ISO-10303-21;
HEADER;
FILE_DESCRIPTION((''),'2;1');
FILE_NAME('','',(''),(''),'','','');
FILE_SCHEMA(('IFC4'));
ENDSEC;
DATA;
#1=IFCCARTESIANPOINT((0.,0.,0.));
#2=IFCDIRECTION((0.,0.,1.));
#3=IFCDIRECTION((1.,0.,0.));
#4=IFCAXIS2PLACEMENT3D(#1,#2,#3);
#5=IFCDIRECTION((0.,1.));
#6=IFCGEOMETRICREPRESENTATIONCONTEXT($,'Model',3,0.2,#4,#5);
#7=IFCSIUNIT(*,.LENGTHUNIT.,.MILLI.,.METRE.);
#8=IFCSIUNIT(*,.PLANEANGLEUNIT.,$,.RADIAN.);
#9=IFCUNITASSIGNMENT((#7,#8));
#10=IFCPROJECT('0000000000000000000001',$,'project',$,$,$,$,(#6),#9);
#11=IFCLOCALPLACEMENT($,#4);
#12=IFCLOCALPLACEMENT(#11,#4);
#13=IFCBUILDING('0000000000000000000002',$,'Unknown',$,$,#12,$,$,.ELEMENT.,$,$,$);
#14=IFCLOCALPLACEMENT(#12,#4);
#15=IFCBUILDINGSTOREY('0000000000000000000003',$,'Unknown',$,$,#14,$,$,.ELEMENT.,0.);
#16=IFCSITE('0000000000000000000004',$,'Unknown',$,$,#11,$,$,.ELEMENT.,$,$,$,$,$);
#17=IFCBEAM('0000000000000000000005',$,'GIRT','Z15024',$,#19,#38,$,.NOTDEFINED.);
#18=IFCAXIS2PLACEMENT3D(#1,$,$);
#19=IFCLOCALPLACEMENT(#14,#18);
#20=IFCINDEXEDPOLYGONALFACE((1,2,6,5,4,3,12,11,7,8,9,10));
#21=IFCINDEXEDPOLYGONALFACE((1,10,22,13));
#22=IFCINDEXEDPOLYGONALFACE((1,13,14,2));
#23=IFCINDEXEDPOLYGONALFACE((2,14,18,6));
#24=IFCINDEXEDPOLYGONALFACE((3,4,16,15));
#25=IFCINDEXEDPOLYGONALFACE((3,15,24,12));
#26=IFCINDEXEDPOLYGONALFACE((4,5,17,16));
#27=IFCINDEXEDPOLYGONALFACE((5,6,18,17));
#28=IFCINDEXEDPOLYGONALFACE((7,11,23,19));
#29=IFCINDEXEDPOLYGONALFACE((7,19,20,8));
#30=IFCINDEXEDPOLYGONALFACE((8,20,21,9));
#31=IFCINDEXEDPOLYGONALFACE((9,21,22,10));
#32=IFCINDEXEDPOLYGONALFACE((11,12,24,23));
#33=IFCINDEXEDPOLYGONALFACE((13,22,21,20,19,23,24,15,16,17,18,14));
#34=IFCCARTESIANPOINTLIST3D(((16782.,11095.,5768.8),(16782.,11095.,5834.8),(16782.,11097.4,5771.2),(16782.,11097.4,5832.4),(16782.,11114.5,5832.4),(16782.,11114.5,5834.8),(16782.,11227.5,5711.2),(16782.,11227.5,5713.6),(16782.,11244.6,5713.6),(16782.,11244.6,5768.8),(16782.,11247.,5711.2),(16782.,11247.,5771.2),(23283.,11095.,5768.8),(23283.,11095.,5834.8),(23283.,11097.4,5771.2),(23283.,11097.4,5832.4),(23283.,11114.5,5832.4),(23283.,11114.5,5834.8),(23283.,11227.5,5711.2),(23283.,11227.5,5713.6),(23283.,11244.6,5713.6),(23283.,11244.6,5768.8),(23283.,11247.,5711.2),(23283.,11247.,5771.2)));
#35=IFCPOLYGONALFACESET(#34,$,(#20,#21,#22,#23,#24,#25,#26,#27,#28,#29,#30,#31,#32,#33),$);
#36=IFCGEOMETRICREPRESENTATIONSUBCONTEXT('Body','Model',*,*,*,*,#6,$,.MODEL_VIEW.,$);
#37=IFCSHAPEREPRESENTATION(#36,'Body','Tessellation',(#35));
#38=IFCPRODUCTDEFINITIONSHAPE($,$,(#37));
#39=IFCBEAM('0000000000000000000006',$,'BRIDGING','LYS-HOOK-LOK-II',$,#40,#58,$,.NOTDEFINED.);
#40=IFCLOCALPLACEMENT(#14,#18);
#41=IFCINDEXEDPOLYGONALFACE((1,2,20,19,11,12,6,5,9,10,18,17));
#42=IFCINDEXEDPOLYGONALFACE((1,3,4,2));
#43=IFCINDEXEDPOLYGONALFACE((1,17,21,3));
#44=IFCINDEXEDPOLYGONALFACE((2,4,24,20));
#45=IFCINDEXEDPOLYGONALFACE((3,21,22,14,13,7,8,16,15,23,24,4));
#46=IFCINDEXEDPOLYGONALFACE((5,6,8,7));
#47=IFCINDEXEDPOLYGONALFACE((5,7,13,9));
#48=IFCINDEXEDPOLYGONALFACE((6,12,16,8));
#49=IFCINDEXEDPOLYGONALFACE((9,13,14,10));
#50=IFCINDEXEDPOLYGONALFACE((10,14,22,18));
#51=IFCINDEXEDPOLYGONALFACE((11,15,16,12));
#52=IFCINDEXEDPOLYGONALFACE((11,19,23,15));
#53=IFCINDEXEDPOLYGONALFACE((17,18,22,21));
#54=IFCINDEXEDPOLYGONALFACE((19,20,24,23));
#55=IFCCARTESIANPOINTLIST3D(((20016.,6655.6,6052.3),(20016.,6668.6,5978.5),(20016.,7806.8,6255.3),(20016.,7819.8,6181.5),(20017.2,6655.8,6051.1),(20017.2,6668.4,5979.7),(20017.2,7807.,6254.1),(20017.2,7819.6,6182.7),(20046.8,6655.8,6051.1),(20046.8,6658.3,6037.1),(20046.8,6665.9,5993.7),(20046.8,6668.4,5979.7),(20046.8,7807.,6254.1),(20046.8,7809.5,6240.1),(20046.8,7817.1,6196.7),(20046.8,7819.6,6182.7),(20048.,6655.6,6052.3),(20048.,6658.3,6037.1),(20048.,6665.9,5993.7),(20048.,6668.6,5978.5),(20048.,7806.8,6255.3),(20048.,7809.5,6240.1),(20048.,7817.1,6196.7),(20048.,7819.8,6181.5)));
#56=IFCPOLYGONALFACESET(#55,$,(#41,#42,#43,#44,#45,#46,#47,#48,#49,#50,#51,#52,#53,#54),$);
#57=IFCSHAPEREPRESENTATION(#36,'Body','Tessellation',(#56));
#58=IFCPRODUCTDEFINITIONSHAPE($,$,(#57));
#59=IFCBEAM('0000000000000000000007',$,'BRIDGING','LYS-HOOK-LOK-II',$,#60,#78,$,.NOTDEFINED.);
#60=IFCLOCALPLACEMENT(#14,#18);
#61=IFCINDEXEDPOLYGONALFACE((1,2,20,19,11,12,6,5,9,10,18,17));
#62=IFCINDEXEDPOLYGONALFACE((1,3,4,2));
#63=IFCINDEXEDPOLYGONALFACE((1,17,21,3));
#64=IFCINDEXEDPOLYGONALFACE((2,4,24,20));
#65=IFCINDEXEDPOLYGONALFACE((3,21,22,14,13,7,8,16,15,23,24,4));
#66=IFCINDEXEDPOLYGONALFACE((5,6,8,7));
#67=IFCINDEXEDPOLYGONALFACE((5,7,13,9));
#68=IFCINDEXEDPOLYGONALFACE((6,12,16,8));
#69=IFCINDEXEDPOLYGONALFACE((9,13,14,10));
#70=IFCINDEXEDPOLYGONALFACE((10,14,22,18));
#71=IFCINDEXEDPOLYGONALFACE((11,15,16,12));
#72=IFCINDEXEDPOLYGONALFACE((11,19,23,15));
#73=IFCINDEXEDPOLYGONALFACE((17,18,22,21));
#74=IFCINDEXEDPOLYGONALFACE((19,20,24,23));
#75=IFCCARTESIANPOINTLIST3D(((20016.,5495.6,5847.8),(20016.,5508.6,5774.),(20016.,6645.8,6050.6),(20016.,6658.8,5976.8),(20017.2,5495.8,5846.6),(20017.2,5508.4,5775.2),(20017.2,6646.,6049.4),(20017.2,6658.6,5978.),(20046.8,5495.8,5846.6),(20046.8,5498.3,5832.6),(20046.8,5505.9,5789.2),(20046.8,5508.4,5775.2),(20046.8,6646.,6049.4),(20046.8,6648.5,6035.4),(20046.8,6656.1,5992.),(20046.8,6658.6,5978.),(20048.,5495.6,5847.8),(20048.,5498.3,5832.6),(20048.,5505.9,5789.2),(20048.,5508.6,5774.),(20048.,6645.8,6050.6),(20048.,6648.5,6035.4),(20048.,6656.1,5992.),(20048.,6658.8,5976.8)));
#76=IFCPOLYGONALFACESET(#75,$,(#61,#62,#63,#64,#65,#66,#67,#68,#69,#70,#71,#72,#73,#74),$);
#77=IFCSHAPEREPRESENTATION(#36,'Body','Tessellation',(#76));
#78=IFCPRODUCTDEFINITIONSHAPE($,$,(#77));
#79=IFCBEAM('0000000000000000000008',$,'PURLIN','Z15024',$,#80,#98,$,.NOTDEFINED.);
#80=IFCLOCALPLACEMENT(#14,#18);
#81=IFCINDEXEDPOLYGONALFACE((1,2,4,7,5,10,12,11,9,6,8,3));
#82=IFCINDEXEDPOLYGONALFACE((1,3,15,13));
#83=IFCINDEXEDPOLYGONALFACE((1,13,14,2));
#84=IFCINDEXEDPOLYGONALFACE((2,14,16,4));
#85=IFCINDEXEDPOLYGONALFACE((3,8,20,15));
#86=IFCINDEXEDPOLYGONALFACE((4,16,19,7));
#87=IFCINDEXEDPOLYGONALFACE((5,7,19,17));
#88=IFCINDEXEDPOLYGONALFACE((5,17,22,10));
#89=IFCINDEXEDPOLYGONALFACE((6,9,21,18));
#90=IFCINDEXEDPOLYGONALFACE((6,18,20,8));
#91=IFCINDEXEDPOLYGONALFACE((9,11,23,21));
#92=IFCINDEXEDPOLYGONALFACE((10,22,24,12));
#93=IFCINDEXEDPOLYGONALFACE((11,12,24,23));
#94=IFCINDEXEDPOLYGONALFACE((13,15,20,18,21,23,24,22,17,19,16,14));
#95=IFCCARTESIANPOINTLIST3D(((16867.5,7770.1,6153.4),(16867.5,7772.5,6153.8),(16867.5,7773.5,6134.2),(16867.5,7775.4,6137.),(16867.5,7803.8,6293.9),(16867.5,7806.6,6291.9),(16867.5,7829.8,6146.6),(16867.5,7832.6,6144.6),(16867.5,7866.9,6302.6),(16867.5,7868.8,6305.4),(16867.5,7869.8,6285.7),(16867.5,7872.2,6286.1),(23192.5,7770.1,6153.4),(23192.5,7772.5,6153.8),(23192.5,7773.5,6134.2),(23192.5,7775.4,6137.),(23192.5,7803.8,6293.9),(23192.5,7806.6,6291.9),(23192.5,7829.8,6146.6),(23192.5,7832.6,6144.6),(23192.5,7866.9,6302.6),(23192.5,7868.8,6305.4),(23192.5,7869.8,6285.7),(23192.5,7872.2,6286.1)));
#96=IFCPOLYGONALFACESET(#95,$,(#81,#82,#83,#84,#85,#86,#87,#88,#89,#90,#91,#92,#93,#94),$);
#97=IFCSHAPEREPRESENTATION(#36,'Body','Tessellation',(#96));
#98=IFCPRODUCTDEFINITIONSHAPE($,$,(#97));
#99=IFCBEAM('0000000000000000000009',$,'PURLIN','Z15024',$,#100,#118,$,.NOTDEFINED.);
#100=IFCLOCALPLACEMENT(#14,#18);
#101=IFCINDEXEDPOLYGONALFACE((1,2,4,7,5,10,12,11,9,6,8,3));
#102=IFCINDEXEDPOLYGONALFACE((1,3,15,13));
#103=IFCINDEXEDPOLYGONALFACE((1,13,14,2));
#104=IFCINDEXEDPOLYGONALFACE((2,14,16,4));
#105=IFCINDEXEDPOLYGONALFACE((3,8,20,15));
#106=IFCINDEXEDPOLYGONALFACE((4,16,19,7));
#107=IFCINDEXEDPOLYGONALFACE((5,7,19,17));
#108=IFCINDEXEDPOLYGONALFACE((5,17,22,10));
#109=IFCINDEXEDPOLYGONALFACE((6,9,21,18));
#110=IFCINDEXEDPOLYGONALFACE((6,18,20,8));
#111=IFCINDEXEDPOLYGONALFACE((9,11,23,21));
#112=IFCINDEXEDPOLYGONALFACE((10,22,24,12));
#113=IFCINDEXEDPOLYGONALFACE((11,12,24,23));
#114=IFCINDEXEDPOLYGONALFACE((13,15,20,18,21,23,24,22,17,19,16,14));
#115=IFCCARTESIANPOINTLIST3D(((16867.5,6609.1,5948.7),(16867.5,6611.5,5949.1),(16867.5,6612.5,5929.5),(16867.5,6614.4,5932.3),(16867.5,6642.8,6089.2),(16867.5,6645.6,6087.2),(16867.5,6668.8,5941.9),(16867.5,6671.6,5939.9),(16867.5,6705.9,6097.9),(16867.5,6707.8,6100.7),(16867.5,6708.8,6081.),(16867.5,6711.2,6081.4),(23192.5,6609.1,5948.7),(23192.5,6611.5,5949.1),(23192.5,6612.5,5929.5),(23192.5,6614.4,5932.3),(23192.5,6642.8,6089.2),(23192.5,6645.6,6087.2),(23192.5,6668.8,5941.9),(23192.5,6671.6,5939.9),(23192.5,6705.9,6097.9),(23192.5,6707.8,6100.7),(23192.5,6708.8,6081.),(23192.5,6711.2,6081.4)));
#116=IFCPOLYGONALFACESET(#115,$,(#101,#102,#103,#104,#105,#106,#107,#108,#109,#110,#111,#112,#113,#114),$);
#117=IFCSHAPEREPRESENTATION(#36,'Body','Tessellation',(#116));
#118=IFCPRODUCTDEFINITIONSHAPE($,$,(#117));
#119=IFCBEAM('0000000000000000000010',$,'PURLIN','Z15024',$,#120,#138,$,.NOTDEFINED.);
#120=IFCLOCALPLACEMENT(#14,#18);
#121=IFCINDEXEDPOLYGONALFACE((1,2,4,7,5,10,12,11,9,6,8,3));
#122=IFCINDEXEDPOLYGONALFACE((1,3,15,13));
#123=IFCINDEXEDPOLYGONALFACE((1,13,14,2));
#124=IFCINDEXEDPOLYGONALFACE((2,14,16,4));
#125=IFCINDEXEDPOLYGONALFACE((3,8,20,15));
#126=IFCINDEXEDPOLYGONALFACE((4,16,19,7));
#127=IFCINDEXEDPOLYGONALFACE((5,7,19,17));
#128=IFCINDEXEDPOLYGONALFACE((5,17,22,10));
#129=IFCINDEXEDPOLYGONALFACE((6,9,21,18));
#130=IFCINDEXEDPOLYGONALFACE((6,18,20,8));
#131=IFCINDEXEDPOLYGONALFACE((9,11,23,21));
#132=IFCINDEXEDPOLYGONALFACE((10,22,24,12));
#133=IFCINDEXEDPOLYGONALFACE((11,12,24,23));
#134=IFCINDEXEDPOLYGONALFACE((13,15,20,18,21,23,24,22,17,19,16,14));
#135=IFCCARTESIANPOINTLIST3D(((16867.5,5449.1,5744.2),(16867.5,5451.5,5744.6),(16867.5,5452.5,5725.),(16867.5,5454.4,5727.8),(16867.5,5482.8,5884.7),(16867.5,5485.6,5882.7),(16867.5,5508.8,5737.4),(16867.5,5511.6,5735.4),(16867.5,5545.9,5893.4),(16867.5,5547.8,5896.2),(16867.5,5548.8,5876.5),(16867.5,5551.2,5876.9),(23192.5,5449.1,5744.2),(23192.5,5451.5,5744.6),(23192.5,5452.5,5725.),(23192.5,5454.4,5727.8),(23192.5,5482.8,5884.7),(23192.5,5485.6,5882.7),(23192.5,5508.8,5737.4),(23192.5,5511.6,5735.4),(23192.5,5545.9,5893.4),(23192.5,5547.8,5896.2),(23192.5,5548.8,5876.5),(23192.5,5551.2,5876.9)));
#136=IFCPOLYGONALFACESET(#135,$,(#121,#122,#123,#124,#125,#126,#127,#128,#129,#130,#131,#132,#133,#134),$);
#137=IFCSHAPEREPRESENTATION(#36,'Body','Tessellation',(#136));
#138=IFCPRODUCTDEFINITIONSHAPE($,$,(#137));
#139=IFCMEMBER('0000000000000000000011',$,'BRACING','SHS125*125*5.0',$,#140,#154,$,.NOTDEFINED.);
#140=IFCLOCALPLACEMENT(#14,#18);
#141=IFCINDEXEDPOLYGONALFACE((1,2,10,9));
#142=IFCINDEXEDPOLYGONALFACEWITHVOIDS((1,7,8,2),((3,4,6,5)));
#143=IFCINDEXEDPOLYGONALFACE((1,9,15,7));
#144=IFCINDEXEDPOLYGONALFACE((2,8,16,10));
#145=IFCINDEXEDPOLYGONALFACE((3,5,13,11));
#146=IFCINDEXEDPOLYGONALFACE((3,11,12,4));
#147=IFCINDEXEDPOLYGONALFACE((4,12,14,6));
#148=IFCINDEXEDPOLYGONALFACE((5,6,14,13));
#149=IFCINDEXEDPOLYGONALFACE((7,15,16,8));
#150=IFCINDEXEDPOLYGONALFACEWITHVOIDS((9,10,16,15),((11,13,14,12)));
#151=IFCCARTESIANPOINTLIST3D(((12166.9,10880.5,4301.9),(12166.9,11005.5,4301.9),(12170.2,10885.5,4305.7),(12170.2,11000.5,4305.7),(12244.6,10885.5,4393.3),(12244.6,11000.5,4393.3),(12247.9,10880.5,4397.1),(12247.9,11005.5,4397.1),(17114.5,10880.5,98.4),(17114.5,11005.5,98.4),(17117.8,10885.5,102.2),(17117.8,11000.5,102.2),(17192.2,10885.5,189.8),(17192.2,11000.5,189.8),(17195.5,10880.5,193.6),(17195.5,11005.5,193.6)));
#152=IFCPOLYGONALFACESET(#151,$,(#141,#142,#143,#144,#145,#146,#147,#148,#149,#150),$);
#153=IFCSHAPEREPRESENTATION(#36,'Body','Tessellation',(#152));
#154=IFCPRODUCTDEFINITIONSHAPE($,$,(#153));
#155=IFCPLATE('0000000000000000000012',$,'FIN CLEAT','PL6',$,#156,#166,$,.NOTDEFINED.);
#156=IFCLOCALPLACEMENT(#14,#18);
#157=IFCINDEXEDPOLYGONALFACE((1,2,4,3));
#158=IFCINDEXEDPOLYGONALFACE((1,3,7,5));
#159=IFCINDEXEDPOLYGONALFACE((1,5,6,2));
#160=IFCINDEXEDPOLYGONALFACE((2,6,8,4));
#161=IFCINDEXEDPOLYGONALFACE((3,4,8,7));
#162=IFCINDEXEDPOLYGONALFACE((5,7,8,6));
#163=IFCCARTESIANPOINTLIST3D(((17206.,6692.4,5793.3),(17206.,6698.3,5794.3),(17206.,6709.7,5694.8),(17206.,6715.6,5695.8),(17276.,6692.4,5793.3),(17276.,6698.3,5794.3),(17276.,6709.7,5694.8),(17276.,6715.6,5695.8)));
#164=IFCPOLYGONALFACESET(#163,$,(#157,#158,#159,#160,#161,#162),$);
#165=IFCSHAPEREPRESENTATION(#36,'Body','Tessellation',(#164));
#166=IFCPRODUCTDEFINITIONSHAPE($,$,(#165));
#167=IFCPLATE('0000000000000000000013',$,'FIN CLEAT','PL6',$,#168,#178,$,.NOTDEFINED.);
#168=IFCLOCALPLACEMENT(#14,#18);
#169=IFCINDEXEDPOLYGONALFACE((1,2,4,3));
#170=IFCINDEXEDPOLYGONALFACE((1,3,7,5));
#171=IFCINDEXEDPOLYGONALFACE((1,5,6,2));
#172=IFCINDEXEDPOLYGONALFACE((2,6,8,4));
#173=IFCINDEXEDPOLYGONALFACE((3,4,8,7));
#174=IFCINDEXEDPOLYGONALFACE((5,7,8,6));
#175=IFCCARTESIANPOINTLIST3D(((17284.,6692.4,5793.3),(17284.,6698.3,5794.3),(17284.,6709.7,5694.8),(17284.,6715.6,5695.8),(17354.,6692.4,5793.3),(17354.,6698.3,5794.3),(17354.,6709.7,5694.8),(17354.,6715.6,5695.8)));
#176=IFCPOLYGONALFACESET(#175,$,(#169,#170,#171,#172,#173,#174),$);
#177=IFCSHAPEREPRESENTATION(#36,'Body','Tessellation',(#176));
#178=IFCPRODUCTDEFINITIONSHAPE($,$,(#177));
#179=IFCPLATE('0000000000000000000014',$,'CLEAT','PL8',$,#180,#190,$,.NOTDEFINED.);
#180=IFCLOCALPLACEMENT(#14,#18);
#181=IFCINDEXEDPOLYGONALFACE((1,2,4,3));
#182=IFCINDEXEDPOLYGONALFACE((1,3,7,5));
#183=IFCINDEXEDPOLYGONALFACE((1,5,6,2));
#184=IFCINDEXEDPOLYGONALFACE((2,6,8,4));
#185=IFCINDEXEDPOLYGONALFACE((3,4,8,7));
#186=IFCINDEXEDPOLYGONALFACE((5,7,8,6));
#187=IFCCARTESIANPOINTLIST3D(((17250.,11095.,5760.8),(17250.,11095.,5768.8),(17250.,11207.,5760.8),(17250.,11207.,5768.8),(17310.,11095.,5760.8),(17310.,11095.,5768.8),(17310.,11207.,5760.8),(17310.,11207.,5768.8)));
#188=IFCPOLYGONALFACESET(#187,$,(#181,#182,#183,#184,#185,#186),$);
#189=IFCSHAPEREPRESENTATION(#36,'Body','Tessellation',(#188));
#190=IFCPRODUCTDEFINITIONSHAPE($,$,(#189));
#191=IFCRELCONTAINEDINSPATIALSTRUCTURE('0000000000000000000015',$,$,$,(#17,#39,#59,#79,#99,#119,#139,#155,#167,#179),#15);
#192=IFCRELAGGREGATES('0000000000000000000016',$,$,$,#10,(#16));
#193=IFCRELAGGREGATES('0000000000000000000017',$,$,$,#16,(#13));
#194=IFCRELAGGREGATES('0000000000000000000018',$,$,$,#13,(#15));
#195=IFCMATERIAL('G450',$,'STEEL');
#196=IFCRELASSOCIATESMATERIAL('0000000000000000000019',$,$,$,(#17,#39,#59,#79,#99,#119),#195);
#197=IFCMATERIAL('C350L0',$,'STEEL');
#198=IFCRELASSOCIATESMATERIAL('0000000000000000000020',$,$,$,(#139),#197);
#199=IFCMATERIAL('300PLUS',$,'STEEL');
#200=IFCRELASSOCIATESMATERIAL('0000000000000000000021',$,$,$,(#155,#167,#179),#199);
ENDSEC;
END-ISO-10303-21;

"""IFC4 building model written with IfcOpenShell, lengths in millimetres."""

from ifc_helpers import new_model, si_unit, direction, frame, origin_with_axes, place, context, subcontext, project, spatial, line, indexed_curve, outline, extrude, material, element, save


model = new_model("IFC4")

# Units and contexts
model_context = context("Model", 3, precision=0.2, world=origin_with_axes(), true_north=direction((0.0, 1.0)))
body_context = subcontext(model_context, "Body", "Model", "MODEL_VIEW")
ifc_project = project(units=[si_unit("LENGTHUNIT", "METRE", prefix="MILLI"), si_unit("PLANEANGLEUNIT", "RADIAN")], contexts=[model_context])

# Site, building, storey
site_placement = place(None, origin_with_axes())
site = spatial("IfcSite", under=ifc_project, at=site_placement, Name="Unknown", CompositionType="ELEMENT")
building_placement = place(site_placement, origin_with_axes())
building = spatial("IfcBuilding", under=site, at=building_placement, Name="Unknown", CompositionType="ELEMENT")
storey_placement = place(building_placement, origin_with_axes())
storey = spatial("IfcBuildingStorey", under=building, at=storey_placement, Name="Unknown", CompositionType="ELEMENT", Elevation=0.0)

# Shared definitions
ifc_material_1 = material(Name="300PLUS", Category="STEEL")

# Beams
ifc_material_2 = material(Name="C350L0", Category="STEEL")
ifc_material_3 = material(Name="G450", Category="STEEL")
for number, where, z_axis, x_axis, name in (
    (1, (16782.0, 11171.0, 5770.0), (0.0, 0.0, -1.0), (1.0, 0.0, 0.0), "GIRT"),
):
    element("IfcBeam", number, at=place(storey_placement, frame(where, z_axis=z_axis, x_axis=x_axis)), inside=storey, material=ifc_material_3, Name=name, Description="Z15024", PredefinedType="NOTDEFINED", context=body_context, shape_type="SolidModel", body=[
        extrude(outline(indexed_curve([(58.8, -76.0), (58.8, -56.5), (56.4, -56.5), (56.4, -73.6), (1.2, -73.6), (1.2, 76.0), (-64.8, 76.0), (-64.8, 56.5), (-62.4, 56.5), (-62.4, 73.6), (-1.2, 73.6), (-1.2, -76.0)], segments=[line(1, 2, 3, 4, 5, 6, 7, 8, 9, 10, 11, 12, 1)])), frame((0.0, 0.0, 0.0), z_axis=(-1.0, 0.0, 0.0), x_axis=(0.0, 0.0, 1.0)), (0.0, 0.0, -1.0), 6501.0),
    ])
beam_1_placement = place(storey_placement, frame((20032.0, 6662.1, 6015.4), z_axis=(1.0, 0.0, 0.0), x_axis=(0.0, 0.984806, 0.173658)))
element("IfcBeam", 2, at=beam_1_placement, inside=storey, material=ifc_material_3, Name="BRIDGING", Description="LYS-HOOK-LOK-II", PredefinedType="NOTDEFINED", context=body_context, shape_type="SolidModel", body=[
    extrude(outline(indexed_curve([(16.0, -37.5), (16.0, -22.0), (14.8, -22.0), (14.8, -36.3), (-14.8, -36.3), (-14.8, 36.3), (14.8, 36.3), (14.8, 22.0), (16.0, 22.0), (16.0, 37.5), (-16.0, 37.5), (-16.0, -37.5)], segments=[line(1, 2, 3, 4, 5, 6, 7, 8, 9, 10, 11, 12, 1)])), frame((0.0, 0.0, 0.0), z_axis=(-1.0, 0.0, 0.0), x_axis=(0.0, 0.0, 1.0)), (0.0, 0.0, -1.0), 1169.0),
])
beam_2_placement = place(storey_placement, frame((20032.0, 5502.1, 5810.9), z_axis=(1.0, 0.0, 0.0), x_axis=(0.0, 0.984809, 0.173639)))
element("IfcBeam", 3, at=beam_2_placement, inside=storey, material=ifc_material_3, Name="BRIDGING", Description="LYS-HOOK-LOK-II", PredefinedType="NOTDEFINED", context=body_context, shape_type="SolidModel", body=[
    extrude(outline(indexed_curve([(16.0, -37.5), (16.0, -22.0), (14.8, -22.0), (14.8, -36.3), (-14.8, -36.3), (-14.8, 36.3), (14.8, 36.3), (14.8, 22.0), (16.0, 22.0), (16.0, 37.5), (-16.0, 37.5), (-16.0, -37.5)], segments=[line(1, 2, 3, 4, 5, 6, 7, 8, 9, 10, 11, 12, 1)])), frame((0.0, 0.0, 0.0), z_axis=(-1.0, 0.0, 0.0), x_axis=(0.0, 0.0, 1.0)), (0.0, 0.0, -1.0), 1167.9),
])
for number, where, z_axis, x_axis, name in (
    (4, (16867.5, 7818.2, 6219.3), (0.0, -0.984808, -0.173648), (1.0, 0.0, 0.0), "PURLIN"),
    (5, (16867.5, 6657.2, 6014.6), (0.0, -0.984808, -0.173648), (1.0, 0.0, 0.0), "PURLIN"),
    (6, (16867.5, 5497.2, 5810.1), (0.0, -0.984808, -0.173648), (1.0, 0.0, 0.0), "PURLIN"),
):
    element("IfcBeam", number, at=place(storey_placement, frame(where, z_axis=z_axis, x_axis=x_axis)), inside=storey, material=ifc_material_3, Name=name, Description="Z15024", PredefinedType="NOTDEFINED", context=body_context, shape_type="SolidModel", body=[
        extrude(outline(indexed_curve([(58.8, -76.0), (58.8, -56.5), (56.4, -56.5), (56.4, -73.6), (1.2, -73.6), (1.2, 76.0), (-64.8, 76.0), (-64.8, 56.5), (-62.4, 56.5), (-62.4, 73.6), (-1.2, 73.6), (-1.2, -76.0)], segments=[line(1, 2, 3, 4, 5, 6, 7, 8, 9, 10, 11, 12, 1)])), frame((0.0, 0.0, 0.0), z_axis=(-1.0, 0.0, 0.0), x_axis=(0.0, 0.0, 1.0)), (0.0, 0.0, -1.0), 6325.0),
    ])

# Member
member_placement = place(storey_placement, frame((17155.0, 10943.0, 146.0), z_axis=(0.647473, 0.0, 0.762088), x_axis=(-0.762088, 0.0, 0.647473)))
element("IfcMember", 7, at=member_placement, inside=storey, material=ifc_material_2, Name="BRACING", Description="SHS125*125*5.0", PredefinedType="NOTDEFINED", context=body_context, shape_type="SolidModel", body=[
    extrude(outline(indexed_curve([(-62.5, -62.5), (62.5, -62.5), (62.5, 62.5), (-62.5, 62.5)], segments=[line(1, 2, 3, 4, 1)]), holes=[indexed_curve([(-57.5, -57.5), (-57.5, 57.5), (57.5, 57.5), (57.5, -57.5)], segments=[line(1, 2, 3, 4, 1)])]), frame((0.0, 0.0, 0.0), z_axis=(-1.0, 0.0, 0.0), x_axis=(0.0, 0.0, 1.0)), (0.0, 0.0, -1.0), 6492.2),
])

# Plates
for number, where, z_axis, x_axis, name in (
    (8, (17206.0, 6695.4, 5793.8), (0.0, 0.984924, 0.172987), (1.0, 0.0, 0.0), "FIN CLEAT"),
    (9, (17284.0, 6695.4, 5793.8), (0.0, 0.984924, 0.172987), (1.0, 0.0, 0.0), "FIN CLEAT"),
):
    element("IfcPlate", number, at=place(storey_placement, frame(where, z_axis=z_axis, x_axis=x_axis)), inside=storey, material=ifc_material_1, Name=name, Description="PL6", PredefinedType="NOTDEFINED", context=body_context, shape_type="SolidModel", body=[
        extrude(outline(indexed_curve([(0.0, 0.0), (70.0, 0.0), (70.0, 100.0), (0.0, 100.0)], segments=[line(1, 2, 3, 4, 1)])), frame((0.0, 0.0, 3.0), z_axis=(0.0, 0.0, 1.0), x_axis=(1.0, 0.0, 0.0)), (0.0, 0.0, -1.0), 6.0),
    ])
for number, where, z_axis, x_axis, name in (
    (10, (17250.0, 11095.0, 5764.8), (0.0, 0.0, 1.0), (1.0, 0.0, 0.0), "CLEAT"),
):
    element("IfcPlate", number, at=place(storey_placement, frame(where, z_axis=z_axis, x_axis=x_axis)), inside=storey, material=ifc_material_1, Name=name, Description="PL8", PredefinedType="NOTDEFINED", context=body_context, shape_type="SolidModel", body=[
        extrude(outline(indexed_curve([(0.0, 0.0), (60.0, 0.0), (60.0, 112.0), (0.0, 112.0)], segments=[line(1, 2, 3, 4, 1)])), frame((0.0, 0.0, 4.0), z_axis=(0.0, 0.0, 1.0), x_axis=(1.0, 0.0, 0.0)), (0.0, 0.0, -1.0), 8.0),
    ])

save(model, "model.ifc")
